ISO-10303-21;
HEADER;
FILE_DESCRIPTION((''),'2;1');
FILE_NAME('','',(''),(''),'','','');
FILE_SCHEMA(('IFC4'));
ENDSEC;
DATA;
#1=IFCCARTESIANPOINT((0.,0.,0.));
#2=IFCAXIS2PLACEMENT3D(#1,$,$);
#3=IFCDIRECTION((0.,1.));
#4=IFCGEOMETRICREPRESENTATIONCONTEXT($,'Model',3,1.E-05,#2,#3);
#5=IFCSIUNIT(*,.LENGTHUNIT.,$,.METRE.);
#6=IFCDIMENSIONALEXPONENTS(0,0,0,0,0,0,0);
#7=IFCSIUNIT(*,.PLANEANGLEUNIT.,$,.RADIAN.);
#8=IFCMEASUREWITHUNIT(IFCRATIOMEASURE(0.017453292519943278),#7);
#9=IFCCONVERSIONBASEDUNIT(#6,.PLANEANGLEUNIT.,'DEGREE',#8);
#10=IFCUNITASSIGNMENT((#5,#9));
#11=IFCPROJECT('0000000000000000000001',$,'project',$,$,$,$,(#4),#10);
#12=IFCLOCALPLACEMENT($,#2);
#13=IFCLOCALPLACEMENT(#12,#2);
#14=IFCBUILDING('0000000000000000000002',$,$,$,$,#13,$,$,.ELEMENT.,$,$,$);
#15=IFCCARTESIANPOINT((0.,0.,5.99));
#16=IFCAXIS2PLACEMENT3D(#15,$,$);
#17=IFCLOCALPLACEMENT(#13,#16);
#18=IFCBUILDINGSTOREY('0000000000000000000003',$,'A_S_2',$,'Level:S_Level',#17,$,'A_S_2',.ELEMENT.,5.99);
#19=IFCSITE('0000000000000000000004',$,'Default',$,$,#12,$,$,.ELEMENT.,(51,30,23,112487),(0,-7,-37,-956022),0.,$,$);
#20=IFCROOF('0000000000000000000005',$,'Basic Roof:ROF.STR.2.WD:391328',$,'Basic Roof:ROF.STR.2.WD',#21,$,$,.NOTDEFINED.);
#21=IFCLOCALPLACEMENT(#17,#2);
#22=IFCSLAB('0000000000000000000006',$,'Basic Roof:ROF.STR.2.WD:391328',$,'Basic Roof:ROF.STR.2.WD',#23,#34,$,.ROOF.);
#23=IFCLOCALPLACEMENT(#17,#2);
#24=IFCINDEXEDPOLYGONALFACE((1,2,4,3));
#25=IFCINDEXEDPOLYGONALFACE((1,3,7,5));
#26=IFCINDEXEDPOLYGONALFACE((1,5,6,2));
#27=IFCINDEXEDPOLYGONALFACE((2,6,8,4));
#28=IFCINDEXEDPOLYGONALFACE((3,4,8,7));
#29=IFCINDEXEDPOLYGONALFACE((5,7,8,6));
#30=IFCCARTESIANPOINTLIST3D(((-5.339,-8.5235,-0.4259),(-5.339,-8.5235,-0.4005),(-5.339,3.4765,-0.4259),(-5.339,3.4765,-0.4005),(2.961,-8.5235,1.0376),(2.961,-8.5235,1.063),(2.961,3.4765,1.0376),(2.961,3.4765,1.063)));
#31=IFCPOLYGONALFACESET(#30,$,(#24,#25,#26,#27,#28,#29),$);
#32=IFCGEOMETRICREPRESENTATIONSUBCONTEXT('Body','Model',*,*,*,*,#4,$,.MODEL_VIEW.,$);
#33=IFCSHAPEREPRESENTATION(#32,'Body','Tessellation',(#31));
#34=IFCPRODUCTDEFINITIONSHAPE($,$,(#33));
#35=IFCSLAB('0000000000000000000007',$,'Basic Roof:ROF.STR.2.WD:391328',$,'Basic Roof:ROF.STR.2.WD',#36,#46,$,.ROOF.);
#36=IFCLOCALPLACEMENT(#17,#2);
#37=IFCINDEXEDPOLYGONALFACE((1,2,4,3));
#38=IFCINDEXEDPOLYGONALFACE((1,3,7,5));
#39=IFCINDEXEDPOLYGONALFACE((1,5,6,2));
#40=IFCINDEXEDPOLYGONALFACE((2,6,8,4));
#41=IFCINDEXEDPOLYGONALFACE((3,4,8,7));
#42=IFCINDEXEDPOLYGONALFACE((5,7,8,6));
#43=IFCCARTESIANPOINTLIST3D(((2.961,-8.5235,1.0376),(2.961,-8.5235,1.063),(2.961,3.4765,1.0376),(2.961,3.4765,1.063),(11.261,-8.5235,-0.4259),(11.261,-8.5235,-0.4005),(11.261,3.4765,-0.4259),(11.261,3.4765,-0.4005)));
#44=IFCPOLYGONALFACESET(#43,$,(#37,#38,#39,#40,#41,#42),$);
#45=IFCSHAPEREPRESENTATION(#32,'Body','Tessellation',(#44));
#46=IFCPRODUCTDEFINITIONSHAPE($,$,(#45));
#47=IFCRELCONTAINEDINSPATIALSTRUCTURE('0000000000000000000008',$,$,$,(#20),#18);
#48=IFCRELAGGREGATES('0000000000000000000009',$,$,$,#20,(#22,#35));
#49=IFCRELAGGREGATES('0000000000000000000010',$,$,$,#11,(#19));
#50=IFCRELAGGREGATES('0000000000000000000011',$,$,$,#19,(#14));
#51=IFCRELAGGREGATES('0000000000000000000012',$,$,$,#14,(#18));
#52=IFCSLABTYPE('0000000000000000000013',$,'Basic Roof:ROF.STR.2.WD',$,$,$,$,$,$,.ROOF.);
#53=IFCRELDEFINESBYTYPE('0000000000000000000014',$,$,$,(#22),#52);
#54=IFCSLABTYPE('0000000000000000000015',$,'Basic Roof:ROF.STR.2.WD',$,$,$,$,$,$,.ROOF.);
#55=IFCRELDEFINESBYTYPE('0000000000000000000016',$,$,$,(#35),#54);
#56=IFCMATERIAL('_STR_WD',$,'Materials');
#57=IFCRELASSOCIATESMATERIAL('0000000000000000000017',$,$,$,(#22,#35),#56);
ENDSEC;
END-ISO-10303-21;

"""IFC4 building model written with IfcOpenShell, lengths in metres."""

from ifc_helpers import new_model, entity, si_unit, converted_unit, direction, frame, origin, place, context, subcontext, project, spatial, indexed_curve, outline, extrude, material, type_object, element, aggregate, save


model = new_model("IFC4")

# Units and contexts
model_context = context("Model", 3, precision=1e-05, world=origin(), true_north=direction((0.0, 1.0)))
body_context = subcontext(model_context, "Body", "Model", "MODEL_VIEW")
ifc_project = project(units=[si_unit("LENGTHUNIT", "METRE"), converted_unit("PLANEANGLEUNIT", "DEGREE", entity("IfcRatioMeasure", 0.017453292519943278), si_unit("PLANEANGLEUNIT", "RADIAN"), dimensions=[0, 0, 0, 0, 0, 0, 0])], contexts=[model_context])

# Site, building, storey
site_placement = place(None, origin())
site = spatial("IfcSite", under=ifc_project, at=site_placement, Name="Default", CompositionType="ELEMENT", RefLatitude=(51, 30, 23, 112487), RefLongitude=(0, -7, -37, -956022), RefElevation=0.0)
building_placement = place(site_placement, origin())
building = spatial("IfcBuilding", under=site, at=building_placement, CompositionType="ELEMENT")
storey_placement = place(building_placement, frame((0.0, 0.0, 5.99)))
storey = spatial("IfcBuildingStorey", under=building, at=storey_placement, Name="A_S_2", ObjectType="Level:S_Level", LongName="A_S_2", CompositionType="ELEMENT", Elevation=5.99)

# Roof, slabs
roof_placement = place(storey_placement, frame((-5.339, -8.5235, -0.4259)))
roof = element("IfcRoof", 1, at=roof_placement, inside=storey, Name="Basic Roof:ROF.STR.2.WD:391328", ObjectType="Basic Roof:ROF.STR.2.WD", PredefinedType="NOTDEFINED")
ifc_material = material(Name="_STR_WD", Category="Materials")
slab_type_1 = type_object("IfcSlabType", Name="Basic Roof:ROF.STR.2.WD", PredefinedType="ROOF")
slab_1_placement = place(roof_placement, origin())
slab_1 = element("IfcSlab", 2, at=slab_1_placement, type_object=slab_type_1, material=ifc_material, Name="Basic Roof:ROF.STR.2.WD:391328", ObjectType="Basic Roof:ROF.STR.2.WD", PredefinedType="ROOF", context=body_context, shape_type="SweptSolid", body=[
    extrude(outline(indexed_curve([(-4.214, -6.0), (4.214, -6.0), (4.214, 6.0), (-4.214, 6.0), (-4.214, -6.0)], self_intersect=False)), frame((4.15, 6.0, 0.7318), z_axis=(-0.173648, 0.0, 0.984808), x_axis=(0.984808, 0.0, 0.173648)), (0.173648, 0.0, 0.984808), 0.0254),
])
slab_type_2 = type_object("IfcSlabType", Name="Basic Roof:ROF.STR.2.WD", PredefinedType="ROOF")
slab_2_placement = place(roof_placement, origin())
slab_2 = element("IfcSlab", 3, at=slab_2_placement, type_object=slab_type_2, material=ifc_material, Name="Basic Roof:ROF.STR.2.WD:391328", ObjectType="Basic Roof:ROF.STR.2.WD", PredefinedType="ROOF", context=body_context, shape_type="SweptSolid", body=[
    extrude(outline(indexed_curve([(-4.214, 6.0), (-4.214, -6.0), (4.214, -6.0), (4.214, 6.0), (-4.214, 6.0)], self_intersect=False)), frame((12.45, 6.0, 0.7318), z_axis=(0.173648, 0.0, 0.984808), x_axis=(0.984808, 0.0, -0.173648)), (-0.173648, 0.0, 0.984808), 0.0254),
])
aggregate(roof, [slab_1, slab_2])

save(model, "model.ifc")
